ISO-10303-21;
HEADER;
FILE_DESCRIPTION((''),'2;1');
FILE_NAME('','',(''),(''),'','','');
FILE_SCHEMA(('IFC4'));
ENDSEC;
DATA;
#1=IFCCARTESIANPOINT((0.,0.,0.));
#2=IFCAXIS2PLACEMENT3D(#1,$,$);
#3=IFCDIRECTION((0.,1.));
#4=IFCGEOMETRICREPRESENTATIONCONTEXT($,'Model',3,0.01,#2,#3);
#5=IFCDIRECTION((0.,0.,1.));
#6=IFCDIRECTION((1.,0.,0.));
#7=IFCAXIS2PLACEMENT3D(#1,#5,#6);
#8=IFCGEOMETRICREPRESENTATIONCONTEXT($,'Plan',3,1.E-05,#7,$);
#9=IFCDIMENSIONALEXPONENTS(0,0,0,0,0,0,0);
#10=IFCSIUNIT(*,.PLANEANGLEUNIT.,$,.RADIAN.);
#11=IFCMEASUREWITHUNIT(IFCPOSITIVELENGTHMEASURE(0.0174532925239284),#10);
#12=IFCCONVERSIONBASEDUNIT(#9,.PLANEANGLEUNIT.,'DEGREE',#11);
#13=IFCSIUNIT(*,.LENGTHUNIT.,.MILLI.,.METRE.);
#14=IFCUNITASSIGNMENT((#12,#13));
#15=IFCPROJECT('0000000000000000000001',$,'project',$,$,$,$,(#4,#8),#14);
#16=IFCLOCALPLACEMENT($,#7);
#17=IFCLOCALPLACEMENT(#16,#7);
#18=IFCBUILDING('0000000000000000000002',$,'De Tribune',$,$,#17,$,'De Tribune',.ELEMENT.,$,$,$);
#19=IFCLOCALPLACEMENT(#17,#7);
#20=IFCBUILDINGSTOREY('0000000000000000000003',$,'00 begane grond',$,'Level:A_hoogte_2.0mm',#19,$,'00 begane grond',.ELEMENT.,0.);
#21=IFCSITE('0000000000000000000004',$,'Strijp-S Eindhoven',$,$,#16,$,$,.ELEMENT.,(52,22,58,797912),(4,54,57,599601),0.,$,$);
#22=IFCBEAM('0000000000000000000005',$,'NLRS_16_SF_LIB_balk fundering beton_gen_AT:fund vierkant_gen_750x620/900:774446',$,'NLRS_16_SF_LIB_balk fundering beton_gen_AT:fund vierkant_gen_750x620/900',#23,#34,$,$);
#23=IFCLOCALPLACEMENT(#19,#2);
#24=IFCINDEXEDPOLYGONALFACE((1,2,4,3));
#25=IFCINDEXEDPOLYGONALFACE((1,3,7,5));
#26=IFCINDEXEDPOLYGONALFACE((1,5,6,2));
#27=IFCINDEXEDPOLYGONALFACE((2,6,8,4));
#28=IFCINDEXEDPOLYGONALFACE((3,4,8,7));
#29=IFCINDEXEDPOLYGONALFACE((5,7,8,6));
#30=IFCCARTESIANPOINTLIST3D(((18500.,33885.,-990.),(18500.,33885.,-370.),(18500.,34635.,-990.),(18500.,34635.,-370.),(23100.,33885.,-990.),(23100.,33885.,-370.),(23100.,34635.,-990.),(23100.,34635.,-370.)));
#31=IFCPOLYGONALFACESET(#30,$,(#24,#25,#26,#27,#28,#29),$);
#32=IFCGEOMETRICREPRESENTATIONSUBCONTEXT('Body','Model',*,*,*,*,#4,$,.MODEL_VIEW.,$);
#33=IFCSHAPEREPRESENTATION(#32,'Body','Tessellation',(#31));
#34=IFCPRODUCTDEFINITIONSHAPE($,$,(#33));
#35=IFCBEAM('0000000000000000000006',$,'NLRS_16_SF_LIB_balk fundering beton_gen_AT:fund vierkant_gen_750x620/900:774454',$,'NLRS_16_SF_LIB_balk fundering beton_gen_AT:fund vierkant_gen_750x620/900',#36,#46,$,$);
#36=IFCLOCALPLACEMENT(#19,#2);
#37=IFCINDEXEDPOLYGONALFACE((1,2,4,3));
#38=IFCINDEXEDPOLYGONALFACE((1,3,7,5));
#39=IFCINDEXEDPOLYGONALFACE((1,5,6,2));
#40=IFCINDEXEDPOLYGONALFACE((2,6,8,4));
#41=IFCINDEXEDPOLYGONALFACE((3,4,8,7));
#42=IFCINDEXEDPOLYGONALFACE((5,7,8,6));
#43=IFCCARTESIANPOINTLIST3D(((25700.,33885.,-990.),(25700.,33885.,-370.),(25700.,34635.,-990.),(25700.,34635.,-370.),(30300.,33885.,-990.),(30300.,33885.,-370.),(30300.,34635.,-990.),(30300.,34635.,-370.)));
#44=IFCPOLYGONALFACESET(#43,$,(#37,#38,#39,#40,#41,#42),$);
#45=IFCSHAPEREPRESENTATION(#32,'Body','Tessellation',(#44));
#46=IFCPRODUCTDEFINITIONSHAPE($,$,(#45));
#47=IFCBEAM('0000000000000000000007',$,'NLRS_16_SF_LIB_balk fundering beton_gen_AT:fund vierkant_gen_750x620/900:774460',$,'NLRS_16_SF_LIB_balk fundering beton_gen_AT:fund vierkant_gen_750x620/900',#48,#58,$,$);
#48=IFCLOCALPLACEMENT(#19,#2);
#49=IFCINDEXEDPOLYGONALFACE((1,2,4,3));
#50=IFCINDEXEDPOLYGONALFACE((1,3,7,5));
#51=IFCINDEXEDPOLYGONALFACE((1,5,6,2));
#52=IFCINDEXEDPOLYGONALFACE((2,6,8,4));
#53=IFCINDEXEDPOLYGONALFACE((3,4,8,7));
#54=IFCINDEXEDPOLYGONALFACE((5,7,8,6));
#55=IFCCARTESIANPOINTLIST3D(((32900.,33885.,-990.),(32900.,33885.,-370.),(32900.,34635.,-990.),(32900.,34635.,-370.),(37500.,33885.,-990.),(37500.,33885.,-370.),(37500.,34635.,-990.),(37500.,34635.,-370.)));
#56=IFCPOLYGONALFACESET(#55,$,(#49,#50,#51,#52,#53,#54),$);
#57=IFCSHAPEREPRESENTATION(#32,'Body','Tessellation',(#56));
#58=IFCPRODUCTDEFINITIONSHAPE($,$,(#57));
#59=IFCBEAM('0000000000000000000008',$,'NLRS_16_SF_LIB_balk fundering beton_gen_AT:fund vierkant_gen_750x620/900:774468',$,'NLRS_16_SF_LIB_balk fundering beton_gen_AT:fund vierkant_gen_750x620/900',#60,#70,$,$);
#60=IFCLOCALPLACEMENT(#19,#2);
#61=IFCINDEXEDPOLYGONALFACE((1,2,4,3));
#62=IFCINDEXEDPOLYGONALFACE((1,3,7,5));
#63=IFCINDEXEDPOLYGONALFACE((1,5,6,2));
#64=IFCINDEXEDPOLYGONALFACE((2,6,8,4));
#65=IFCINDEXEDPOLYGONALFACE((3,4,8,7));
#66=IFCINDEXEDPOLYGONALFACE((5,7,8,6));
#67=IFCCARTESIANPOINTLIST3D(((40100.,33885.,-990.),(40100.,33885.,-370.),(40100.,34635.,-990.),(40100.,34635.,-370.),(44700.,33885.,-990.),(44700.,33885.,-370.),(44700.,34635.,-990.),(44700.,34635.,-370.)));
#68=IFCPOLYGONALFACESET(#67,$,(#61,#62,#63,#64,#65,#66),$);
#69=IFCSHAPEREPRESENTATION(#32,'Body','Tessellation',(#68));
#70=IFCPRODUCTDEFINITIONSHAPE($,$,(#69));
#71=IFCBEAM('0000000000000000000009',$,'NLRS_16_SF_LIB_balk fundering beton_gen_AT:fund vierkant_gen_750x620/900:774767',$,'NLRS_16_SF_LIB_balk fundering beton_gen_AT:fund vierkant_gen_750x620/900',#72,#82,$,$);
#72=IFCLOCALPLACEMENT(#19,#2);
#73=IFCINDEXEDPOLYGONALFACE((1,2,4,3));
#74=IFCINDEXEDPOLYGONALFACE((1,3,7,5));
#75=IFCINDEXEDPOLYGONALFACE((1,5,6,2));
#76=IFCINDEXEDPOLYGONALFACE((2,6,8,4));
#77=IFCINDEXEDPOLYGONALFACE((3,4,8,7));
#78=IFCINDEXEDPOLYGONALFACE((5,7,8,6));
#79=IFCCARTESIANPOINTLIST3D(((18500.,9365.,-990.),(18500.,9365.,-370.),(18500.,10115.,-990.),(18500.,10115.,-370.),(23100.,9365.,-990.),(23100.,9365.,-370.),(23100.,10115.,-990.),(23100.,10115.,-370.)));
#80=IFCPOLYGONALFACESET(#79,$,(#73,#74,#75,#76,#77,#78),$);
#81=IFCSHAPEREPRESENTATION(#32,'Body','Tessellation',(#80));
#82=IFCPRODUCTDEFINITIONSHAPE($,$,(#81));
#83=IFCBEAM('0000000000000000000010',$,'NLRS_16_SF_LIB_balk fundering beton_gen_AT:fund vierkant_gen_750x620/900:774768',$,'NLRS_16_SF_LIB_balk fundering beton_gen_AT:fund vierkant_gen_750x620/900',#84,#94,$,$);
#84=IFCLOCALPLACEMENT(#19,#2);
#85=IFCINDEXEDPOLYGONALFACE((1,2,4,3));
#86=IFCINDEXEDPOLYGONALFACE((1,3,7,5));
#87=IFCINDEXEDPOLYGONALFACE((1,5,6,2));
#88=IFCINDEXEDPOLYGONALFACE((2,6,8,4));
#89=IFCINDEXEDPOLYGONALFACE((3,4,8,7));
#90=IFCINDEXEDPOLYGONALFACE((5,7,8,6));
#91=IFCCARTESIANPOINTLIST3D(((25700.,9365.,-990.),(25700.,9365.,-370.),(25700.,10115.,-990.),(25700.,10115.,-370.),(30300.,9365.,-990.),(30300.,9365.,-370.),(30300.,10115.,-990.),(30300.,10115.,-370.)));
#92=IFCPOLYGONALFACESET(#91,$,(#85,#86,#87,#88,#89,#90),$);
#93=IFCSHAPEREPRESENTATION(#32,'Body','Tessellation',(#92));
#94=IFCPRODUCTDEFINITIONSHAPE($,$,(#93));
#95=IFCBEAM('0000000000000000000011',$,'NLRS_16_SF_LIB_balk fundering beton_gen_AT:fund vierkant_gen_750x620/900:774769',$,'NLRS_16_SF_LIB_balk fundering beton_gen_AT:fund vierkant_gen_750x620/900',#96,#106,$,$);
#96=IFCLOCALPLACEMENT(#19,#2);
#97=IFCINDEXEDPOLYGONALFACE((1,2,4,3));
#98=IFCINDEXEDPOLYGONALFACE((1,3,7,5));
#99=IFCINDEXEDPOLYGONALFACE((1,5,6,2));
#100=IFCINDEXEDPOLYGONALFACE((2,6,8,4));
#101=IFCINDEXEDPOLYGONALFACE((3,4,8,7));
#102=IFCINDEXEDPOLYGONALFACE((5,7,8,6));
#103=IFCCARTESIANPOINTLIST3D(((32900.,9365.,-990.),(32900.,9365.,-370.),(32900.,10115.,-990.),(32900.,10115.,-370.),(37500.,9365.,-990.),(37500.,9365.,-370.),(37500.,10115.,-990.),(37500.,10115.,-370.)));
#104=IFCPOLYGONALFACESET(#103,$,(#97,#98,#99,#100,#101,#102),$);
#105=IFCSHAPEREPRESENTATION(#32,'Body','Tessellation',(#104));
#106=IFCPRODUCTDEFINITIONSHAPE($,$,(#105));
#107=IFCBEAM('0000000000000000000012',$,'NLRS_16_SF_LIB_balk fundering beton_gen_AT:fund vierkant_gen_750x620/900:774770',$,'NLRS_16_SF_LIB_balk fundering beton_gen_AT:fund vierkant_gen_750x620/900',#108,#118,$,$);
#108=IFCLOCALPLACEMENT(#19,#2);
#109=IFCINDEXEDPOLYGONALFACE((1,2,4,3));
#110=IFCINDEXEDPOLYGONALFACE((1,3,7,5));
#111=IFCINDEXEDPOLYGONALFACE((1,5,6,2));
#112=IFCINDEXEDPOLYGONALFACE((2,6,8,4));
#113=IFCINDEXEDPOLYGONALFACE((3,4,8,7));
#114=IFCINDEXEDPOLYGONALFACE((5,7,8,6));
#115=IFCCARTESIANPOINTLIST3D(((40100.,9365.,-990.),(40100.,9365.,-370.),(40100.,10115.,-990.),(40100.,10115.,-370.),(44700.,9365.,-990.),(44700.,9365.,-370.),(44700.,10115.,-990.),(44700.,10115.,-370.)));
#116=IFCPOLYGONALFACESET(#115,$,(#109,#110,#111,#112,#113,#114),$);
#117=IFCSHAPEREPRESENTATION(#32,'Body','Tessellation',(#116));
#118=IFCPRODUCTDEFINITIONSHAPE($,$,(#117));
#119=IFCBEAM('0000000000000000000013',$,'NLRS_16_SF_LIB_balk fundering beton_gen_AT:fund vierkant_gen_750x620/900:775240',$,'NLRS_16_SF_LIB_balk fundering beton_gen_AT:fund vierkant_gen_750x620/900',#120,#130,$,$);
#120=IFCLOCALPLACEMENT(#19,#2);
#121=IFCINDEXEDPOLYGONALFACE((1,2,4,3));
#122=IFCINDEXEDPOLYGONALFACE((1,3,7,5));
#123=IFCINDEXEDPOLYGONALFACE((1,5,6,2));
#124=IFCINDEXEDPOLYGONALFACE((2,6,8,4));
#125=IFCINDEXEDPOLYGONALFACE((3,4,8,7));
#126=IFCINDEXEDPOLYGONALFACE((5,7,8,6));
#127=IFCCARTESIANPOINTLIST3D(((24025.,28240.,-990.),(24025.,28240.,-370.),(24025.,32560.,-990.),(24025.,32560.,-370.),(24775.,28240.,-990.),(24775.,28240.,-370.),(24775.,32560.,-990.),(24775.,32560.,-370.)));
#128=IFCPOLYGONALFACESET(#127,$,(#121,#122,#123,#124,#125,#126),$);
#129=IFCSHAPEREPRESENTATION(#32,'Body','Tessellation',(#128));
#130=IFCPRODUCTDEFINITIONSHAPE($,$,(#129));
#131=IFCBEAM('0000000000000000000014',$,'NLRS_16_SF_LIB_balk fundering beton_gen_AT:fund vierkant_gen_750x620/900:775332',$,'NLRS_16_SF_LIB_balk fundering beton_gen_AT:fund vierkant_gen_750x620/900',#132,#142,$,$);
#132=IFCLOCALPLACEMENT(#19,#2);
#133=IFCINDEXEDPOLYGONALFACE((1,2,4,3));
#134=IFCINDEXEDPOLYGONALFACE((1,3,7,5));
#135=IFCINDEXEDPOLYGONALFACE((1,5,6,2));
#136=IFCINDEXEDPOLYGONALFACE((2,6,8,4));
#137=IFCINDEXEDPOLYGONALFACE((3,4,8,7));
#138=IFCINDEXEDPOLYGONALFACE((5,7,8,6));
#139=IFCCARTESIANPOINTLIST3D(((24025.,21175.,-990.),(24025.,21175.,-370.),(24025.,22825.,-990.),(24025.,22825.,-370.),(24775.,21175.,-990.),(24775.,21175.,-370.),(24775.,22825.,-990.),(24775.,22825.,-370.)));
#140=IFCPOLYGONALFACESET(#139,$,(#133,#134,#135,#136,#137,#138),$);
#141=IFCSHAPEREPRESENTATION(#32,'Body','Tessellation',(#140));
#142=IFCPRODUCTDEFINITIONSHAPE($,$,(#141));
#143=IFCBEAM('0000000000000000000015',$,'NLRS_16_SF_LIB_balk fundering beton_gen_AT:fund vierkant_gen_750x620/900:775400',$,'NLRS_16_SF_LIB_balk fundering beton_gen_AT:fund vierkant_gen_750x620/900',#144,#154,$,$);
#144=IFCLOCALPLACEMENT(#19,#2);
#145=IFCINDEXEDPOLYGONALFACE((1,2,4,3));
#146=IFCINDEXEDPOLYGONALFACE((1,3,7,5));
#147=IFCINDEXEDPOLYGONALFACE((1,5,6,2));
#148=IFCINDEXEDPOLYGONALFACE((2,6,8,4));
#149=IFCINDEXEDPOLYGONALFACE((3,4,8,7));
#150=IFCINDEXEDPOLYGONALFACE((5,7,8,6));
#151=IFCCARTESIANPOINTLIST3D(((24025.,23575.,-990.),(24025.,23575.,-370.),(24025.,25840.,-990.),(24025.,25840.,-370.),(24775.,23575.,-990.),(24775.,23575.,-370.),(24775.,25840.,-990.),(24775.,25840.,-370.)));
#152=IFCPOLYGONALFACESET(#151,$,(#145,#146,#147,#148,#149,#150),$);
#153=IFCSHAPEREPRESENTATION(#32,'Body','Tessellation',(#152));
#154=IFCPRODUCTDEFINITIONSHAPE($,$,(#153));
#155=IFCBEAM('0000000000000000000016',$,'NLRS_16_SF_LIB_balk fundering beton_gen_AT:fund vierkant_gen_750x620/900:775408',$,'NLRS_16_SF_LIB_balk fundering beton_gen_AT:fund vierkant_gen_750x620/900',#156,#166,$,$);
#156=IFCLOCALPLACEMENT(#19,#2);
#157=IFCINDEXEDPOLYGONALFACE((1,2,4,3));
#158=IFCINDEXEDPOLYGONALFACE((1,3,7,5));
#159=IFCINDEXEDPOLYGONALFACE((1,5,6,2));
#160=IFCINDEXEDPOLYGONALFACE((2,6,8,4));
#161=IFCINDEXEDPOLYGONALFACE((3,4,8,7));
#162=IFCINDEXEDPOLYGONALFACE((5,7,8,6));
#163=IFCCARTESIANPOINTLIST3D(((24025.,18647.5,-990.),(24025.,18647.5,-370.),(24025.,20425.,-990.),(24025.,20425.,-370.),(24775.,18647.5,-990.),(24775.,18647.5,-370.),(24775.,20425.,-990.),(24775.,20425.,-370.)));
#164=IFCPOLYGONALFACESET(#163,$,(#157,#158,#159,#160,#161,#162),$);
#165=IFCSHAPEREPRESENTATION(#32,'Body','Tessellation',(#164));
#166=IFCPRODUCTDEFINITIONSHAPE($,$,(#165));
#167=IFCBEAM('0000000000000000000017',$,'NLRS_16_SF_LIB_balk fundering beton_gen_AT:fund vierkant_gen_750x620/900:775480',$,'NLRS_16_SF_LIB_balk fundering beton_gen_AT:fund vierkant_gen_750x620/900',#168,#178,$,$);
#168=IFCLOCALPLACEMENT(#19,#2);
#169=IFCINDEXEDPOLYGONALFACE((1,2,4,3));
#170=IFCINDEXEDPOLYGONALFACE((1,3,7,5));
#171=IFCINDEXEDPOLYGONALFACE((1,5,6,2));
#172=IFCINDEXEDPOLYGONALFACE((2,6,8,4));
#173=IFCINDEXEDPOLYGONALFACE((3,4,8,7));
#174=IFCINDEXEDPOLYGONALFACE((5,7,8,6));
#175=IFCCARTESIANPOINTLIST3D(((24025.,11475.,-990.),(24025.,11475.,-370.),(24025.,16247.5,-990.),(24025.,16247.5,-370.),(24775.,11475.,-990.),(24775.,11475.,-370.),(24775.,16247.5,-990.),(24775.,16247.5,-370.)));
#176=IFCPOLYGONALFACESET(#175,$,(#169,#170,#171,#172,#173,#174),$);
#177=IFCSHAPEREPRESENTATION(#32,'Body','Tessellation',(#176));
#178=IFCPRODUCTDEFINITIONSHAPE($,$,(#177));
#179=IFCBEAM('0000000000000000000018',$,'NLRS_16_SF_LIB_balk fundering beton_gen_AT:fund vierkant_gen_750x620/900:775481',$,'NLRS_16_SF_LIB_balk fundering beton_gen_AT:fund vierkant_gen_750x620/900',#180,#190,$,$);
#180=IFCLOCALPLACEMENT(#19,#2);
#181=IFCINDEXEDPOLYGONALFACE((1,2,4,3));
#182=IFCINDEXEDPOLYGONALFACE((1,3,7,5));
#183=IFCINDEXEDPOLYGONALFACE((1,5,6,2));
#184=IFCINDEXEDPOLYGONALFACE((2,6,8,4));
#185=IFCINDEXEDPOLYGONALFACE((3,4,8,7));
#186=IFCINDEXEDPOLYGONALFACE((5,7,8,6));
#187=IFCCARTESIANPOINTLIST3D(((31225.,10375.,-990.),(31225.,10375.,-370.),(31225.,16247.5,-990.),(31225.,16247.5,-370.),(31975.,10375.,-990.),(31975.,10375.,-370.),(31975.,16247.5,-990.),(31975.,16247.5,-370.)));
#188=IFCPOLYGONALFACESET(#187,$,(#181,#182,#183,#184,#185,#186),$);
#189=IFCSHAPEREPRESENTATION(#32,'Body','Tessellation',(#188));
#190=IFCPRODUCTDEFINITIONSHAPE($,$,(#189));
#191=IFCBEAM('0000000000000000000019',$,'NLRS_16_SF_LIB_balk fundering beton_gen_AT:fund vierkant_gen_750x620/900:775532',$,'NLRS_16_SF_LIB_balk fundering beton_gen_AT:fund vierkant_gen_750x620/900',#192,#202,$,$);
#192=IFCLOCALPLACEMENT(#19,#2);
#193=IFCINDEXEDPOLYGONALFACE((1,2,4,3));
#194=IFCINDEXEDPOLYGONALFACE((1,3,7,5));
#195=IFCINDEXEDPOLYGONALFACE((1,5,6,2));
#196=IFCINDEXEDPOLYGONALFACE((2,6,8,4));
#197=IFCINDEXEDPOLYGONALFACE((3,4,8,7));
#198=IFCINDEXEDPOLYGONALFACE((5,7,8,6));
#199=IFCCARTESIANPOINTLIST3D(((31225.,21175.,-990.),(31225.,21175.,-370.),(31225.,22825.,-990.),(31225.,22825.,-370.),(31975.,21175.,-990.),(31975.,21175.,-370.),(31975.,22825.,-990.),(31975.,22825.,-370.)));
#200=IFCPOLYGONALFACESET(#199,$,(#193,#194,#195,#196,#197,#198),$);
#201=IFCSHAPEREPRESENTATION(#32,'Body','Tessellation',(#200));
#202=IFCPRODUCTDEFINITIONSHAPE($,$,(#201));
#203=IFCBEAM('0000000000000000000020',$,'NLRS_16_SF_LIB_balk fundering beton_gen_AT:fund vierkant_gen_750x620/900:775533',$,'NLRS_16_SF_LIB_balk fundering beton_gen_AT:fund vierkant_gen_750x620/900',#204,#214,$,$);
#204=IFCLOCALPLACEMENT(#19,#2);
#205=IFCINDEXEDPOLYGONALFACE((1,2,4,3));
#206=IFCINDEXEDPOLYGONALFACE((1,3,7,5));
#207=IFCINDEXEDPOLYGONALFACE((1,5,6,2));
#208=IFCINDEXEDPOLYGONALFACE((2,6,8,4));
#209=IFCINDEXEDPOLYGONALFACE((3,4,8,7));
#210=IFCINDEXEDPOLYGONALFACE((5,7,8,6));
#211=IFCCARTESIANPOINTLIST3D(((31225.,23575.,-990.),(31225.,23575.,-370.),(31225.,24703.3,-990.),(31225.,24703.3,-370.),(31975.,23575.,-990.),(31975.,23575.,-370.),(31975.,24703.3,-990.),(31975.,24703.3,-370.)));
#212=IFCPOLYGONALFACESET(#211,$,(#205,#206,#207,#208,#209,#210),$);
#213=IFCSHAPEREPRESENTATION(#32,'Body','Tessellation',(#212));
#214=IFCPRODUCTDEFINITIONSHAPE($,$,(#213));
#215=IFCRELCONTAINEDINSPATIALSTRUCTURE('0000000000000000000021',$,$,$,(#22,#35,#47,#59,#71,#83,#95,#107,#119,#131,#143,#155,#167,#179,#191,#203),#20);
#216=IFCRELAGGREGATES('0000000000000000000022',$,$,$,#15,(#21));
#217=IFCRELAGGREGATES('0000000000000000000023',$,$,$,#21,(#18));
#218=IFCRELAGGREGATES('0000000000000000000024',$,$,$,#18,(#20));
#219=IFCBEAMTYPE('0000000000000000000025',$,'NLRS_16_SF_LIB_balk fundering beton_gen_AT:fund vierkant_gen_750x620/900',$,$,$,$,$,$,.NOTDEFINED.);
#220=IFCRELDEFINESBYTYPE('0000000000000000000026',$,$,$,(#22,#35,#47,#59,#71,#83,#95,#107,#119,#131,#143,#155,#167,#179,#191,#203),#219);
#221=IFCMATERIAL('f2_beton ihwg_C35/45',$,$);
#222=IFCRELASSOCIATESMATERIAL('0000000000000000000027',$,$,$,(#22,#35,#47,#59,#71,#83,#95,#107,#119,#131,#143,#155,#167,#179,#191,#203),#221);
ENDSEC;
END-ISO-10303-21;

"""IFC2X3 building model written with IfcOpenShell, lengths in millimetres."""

from ifc_helpers import new_model, entity, si_unit, converted_unit, direction, frame, frame_2d, origin, origin_with_axes, origin_2d_with_axis, place, context, subcontext, project, spatial, rectangle, extrude, material, type_object, element, save


model = new_model("IFC2X3")

# Units and contexts
model_context = context("Model", 3, precision=0.01, world=origin(), true_north=direction((0.0, 1.0)))
plan_context = context("Plan", 3, precision=1e-05, world=origin_with_axes())
body_context = subcontext(model_context, "Body", "Model", "MODEL_VIEW")
ifc_project = project(units=[converted_unit("PLANEANGLEUNIT", "DEGREE", entity("IfcPositiveLengthMeasure", 0.0174532925239284), si_unit("PLANEANGLEUNIT", "RADIAN"), dimensions=[0, 0, 0, 0, 0, 0, 0]), si_unit("LENGTHUNIT", "METRE", prefix="MILLI")], contexts=[model_context, plan_context])

# Site, building, storey
site_placement = place(None, origin_with_axes())
site = spatial("IfcSite", under=ifc_project, at=site_placement, Name="Strijp-S Eindhoven", CompositionType="ELEMENT", RefLatitude=(52, 22, 58, 797912), RefLongitude=(4, 54, 57, 599601), RefElevation=0.0)
building_placement = place(site_placement, origin_with_axes())
building = spatial("IfcBuilding", under=site, at=building_placement, Name="De Tribune", LongName="De Tribune", CompositionType="ELEMENT")
storey_placement = place(building_placement, origin_with_axes())
storey = spatial("IfcBuildingStorey", under=building, at=storey_placement, Name="00 begane grond", ObjectType="Level:A_hoogte_2.0mm", LongName="00 begane grond", CompositionType="ELEMENT", Elevation=0.0)

# Beams
ifc_material_1 = material(Name="f2_beton ihwg_C35/45")
beam_type_1 = type_object("IfcBeamType", Name="NLRS_16_SF_LIB_balk fundering beton_gen_AT:fund vierkant_gen_750x620/900", PredefinedType="NOTDEFINED")
for number, where, z_axis, x_axis, name in (
    (1, (18500.0, 34260.0, 0.0), (0.0, 0.0, 1.0), (1.0, 0.0, 0.0), "NLRS_16_SF_LIB_balk fundering beton_gen_AT:fund vierkant_gen_750x620/900:774446"),
    (2, (25700.0, 34260.0, 0.0), (0.0, 0.0, 1.0), (1.0, 0.0, 0.0), "NLRS_16_SF_LIB_balk fundering beton_gen_AT:fund vierkant_gen_750x620/900:774454"),
    (3, (32900.0, 34260.0, 0.0), (0.0, 0.0, 1.0), (1.0, 0.0, 0.0), "NLRS_16_SF_LIB_balk fundering beton_gen_AT:fund vierkant_gen_750x620/900:774460"),
    (4, (40100.0, 34260.0, 0.0), (0.0, 0.0, 1.0), (1.0, 0.0, 0.0), "NLRS_16_SF_LIB_balk fundering beton_gen_AT:fund vierkant_gen_750x620/900:774468"),
    (5, (18500.0, 9740.0, 0.0), (0.0, 0.0, 1.0), (1.0, 0.0, 0.0), "NLRS_16_SF_LIB_balk fundering beton_gen_AT:fund vierkant_gen_750x620/900:774767"),
    (6, (25700.0, 9740.0, 0.0), (0.0, 0.0, 1.0), (1.0, 0.0, 0.0), "NLRS_16_SF_LIB_balk fundering beton_gen_AT:fund vierkant_gen_750x620/900:774768"),
    (7, (32900.0, 9740.0, 0.0), (0.0, 0.0, 1.0), (1.0, 0.0, 0.0), "NLRS_16_SF_LIB_balk fundering beton_gen_AT:fund vierkant_gen_750x620/900:774769"),
    (8, (40100.0, 9740.0, 0.0), (0.0, 0.0, 1.0), (1.0, 0.0, 0.0), "NLRS_16_SF_LIB_balk fundering beton_gen_AT:fund vierkant_gen_750x620/900:774770"),
):
    element("IfcBeam", number, at=place(storey_placement, frame(where, z_axis=z_axis, x_axis=x_axis)), inside=storey, type_object=beam_type_1, material=ifc_material_1, Name=name, ObjectType="NLRS_16_SF_LIB_balk fundering beton_gen_AT:fund vierkant_gen_750x620/900", context=body_context, shape_type="SweptSolid", body=[
        extrude(rectangle(XDim=620.0, YDim=750.0, at=frame_2d((0.0, 0.0), x_axis=(1.0, 0.0))), frame((0.0, 0.0, -680.0), z_axis=(1.0, 0.0, 0.0), x_axis=(0.0, 0.0, -1.0)), (0.0, 0.0, 1.0), 4600.0),
    ])
beam_1_placement = place(storey_placement, frame((24400.0, 28240.0, 0.0), z_axis=(0.0, 0.0, 1.0), x_axis=(0.0, 1.0, 0.0)))
element("IfcBeam", 9, at=beam_1_placement, inside=storey, type_object=beam_type_1, material=ifc_material_1, Name="NLRS_16_SF_LIB_balk fundering beton_gen_AT:fund vierkant_gen_750x620/900:775240", ObjectType="NLRS_16_SF_LIB_balk fundering beton_gen_AT:fund vierkant_gen_750x620/900", context=body_context, shape_type="SweptSolid", body=[
    extrude(rectangle(XDim=620.0, YDim=750.0, at=frame_2d((0.0, 0.0), x_axis=(1.0, 0.0))), frame((0.0, 0.0, -680.0), z_axis=(1.0, 0.0, 0.0), x_axis=(0.0, 0.0, -1.0)), (0.0, 0.0, 1.0), 4320.0),
])
beam_2_placement = place(storey_placement, frame((24400.0, 21175.0, 0.0), z_axis=(0.0, 0.0, 1.0), x_axis=(0.0, 1.0, 0.0)))
element("IfcBeam", 10, at=beam_2_placement, inside=storey, type_object=beam_type_1, material=ifc_material_1, Name="NLRS_16_SF_LIB_balk fundering beton_gen_AT:fund vierkant_gen_750x620/900:775332", ObjectType="NLRS_16_SF_LIB_balk fundering beton_gen_AT:fund vierkant_gen_750x620/900", context=body_context, shape_type="SweptSolid", body=[
    extrude(rectangle(XDim=620.0, YDim=750.0, at=origin_2d_with_axis()), frame((0.0, 0.0, -680.0), z_axis=(1.0, 0.0, 0.0), x_axis=(0.0, 0.0, -1.0)), (0.0, 0.0, 1.0), 1650.0),
])
beam_3_placement = place(storey_placement, frame((24400.0, 23575.0, 0.0), z_axis=(0.0, 0.0, 1.0), x_axis=(0.0, 1.0, 0.0)))
element("IfcBeam", 11, at=beam_3_placement, inside=storey, type_object=beam_type_1, material=ifc_material_1, Name="NLRS_16_SF_LIB_balk fundering beton_gen_AT:fund vierkant_gen_750x620/900:775400", ObjectType="NLRS_16_SF_LIB_balk fundering beton_gen_AT:fund vierkant_gen_750x620/900", context=body_context, shape_type="SweptSolid", body=[
    extrude(rectangle(XDim=620.0, YDim=750.0, at=frame_2d((0.0, 0.0), x_axis=(1.0, 0.0))), frame((0.0, 0.0, -680.0), z_axis=(1.0, 0.0, 0.0), x_axis=(0.0, 0.0, -1.0)), (0.0, 0.0, 1.0), 2265.0),
])
beam_4_placement = place(storey_placement, frame((24400.0, 18647.5, 0.0), z_axis=(0.0, 0.0, 1.0), x_axis=(0.0, 1.0, 0.0)))
element("IfcBeam", 12, at=beam_4_placement, inside=storey, type_object=beam_type_1, material=ifc_material_1, Name="NLRS_16_SF_LIB_balk fundering beton_gen_AT:fund vierkant_gen_750x620/900:775408", ObjectType="NLRS_16_SF_LIB_balk fundering beton_gen_AT:fund vierkant_gen_750x620/900", context=body_context, shape_type="SweptSolid", body=[
    extrude(rectangle(XDim=620.0, YDim=750.0, at=frame_2d((0.0, 0.0), x_axis=(1.0, 0.0))), frame((0.0, 0.0, -680.0), z_axis=(1.0, 0.0, 0.0), x_axis=(0.0, 0.0, -1.0)), (0.0, 0.0, 1.0), 1777.5),
])
beam_5_placement = place(storey_placement, frame((24400.0, 11475.0, 0.0), z_axis=(0.0, 0.0, 1.0), x_axis=(0.0, 1.0, 0.0)))
element("IfcBeam", 13, at=beam_5_placement, inside=storey, type_object=beam_type_1, material=ifc_material_1, Name="NLRS_16_SF_LIB_balk fundering beton_gen_AT:fund vierkant_gen_750x620/900:775480", ObjectType="NLRS_16_SF_LIB_balk fundering beton_gen_AT:fund vierkant_gen_750x620/900", context=body_context, shape_type="SweptSolid", body=[
    extrude(rectangle(XDim=620.0, YDim=750.0, at=frame_2d((0.0, 0.0), x_axis=(1.0, 0.0))), frame((0.0, 0.0, -680.0), z_axis=(1.0, 0.0, 0.0), x_axis=(0.0, 0.0, -1.0)), (0.0, 0.0, 1.0), 4772.5),
])
beam_6_placement = place(storey_placement, frame((31600.0, 10375.0, 0.0), z_axis=(0.0, 0.0, 1.0), x_axis=(0.0, 1.0, 0.0)))
element("IfcBeam", 14, at=beam_6_placement, inside=storey, type_object=beam_type_1, material=ifc_material_1, Name="NLRS_16_SF_LIB_balk fundering beton_gen_AT:fund vierkant_gen_750x620/900:775481", ObjectType="NLRS_16_SF_LIB_balk fundering beton_gen_AT:fund vierkant_gen_750x620/900", context=body_context, shape_type="SweptSolid", body=[
    extrude(rectangle(XDim=620.0, YDim=750.0, at=frame_2d((0.0, 0.0), x_axis=(1.0, 0.0))), frame((0.0, 0.0, -680.0), z_axis=(1.0, 0.0, 0.0), x_axis=(0.0, 0.0, -1.0)), (0.0, 0.0, 1.0), 5872.5),
])
beam_7_placement = place(storey_placement, frame((31600.0, 21175.0, 0.0), z_axis=(0.0, 0.0, 1.0), x_axis=(0.0, 1.0, 0.0)))
element("IfcBeam", 15, at=beam_7_placement, inside=storey, type_object=beam_type_1, material=ifc_material_1, Name="NLRS_16_SF_LIB_balk fundering beton_gen_AT:fund vierkant_gen_750x620/900:775532", ObjectType="NLRS_16_SF_LIB_balk fundering beton_gen_AT:fund vierkant_gen_750x620/900", context=body_context, shape_type="SweptSolid", body=[
    extrude(rectangle(XDim=620.0, YDim=750.0, at=origin_2d_with_axis()), frame((0.0, 0.0, -680.0), z_axis=(1.0, 0.0, 0.0), x_axis=(0.0, 0.0, -1.0)), (0.0, 0.0, 1.0), 1650.0),
])
beam_8_placement = place(storey_placement, frame((31600.0, 23575.0, 0.0), z_axis=(0.0, 0.0, 1.0), x_axis=(0.0, 1.0, 0.0)))
element("IfcBeam", 16, at=beam_8_placement, inside=storey, type_object=beam_type_1, material=ifc_material_1, Name="NLRS_16_SF_LIB_balk fundering beton_gen_AT:fund vierkant_gen_750x620/900:775533", ObjectType="NLRS_16_SF_LIB_balk fundering beton_gen_AT:fund vierkant_gen_750x620/900", context=body_context, shape_type="SweptSolid", body=[
    extrude(rectangle(XDim=620.0, YDim=750.0, at=frame_2d((0.0, 0.0), x_axis=(1.0, 0.0))), frame((0.0, 0.0, -680.0), z_axis=(1.0, 0.0, 0.0), x_axis=(0.0, 0.0, -1.0)), (0.0, 0.0, 1.0), 1128.3),
])

save(model, "model.ifc")
